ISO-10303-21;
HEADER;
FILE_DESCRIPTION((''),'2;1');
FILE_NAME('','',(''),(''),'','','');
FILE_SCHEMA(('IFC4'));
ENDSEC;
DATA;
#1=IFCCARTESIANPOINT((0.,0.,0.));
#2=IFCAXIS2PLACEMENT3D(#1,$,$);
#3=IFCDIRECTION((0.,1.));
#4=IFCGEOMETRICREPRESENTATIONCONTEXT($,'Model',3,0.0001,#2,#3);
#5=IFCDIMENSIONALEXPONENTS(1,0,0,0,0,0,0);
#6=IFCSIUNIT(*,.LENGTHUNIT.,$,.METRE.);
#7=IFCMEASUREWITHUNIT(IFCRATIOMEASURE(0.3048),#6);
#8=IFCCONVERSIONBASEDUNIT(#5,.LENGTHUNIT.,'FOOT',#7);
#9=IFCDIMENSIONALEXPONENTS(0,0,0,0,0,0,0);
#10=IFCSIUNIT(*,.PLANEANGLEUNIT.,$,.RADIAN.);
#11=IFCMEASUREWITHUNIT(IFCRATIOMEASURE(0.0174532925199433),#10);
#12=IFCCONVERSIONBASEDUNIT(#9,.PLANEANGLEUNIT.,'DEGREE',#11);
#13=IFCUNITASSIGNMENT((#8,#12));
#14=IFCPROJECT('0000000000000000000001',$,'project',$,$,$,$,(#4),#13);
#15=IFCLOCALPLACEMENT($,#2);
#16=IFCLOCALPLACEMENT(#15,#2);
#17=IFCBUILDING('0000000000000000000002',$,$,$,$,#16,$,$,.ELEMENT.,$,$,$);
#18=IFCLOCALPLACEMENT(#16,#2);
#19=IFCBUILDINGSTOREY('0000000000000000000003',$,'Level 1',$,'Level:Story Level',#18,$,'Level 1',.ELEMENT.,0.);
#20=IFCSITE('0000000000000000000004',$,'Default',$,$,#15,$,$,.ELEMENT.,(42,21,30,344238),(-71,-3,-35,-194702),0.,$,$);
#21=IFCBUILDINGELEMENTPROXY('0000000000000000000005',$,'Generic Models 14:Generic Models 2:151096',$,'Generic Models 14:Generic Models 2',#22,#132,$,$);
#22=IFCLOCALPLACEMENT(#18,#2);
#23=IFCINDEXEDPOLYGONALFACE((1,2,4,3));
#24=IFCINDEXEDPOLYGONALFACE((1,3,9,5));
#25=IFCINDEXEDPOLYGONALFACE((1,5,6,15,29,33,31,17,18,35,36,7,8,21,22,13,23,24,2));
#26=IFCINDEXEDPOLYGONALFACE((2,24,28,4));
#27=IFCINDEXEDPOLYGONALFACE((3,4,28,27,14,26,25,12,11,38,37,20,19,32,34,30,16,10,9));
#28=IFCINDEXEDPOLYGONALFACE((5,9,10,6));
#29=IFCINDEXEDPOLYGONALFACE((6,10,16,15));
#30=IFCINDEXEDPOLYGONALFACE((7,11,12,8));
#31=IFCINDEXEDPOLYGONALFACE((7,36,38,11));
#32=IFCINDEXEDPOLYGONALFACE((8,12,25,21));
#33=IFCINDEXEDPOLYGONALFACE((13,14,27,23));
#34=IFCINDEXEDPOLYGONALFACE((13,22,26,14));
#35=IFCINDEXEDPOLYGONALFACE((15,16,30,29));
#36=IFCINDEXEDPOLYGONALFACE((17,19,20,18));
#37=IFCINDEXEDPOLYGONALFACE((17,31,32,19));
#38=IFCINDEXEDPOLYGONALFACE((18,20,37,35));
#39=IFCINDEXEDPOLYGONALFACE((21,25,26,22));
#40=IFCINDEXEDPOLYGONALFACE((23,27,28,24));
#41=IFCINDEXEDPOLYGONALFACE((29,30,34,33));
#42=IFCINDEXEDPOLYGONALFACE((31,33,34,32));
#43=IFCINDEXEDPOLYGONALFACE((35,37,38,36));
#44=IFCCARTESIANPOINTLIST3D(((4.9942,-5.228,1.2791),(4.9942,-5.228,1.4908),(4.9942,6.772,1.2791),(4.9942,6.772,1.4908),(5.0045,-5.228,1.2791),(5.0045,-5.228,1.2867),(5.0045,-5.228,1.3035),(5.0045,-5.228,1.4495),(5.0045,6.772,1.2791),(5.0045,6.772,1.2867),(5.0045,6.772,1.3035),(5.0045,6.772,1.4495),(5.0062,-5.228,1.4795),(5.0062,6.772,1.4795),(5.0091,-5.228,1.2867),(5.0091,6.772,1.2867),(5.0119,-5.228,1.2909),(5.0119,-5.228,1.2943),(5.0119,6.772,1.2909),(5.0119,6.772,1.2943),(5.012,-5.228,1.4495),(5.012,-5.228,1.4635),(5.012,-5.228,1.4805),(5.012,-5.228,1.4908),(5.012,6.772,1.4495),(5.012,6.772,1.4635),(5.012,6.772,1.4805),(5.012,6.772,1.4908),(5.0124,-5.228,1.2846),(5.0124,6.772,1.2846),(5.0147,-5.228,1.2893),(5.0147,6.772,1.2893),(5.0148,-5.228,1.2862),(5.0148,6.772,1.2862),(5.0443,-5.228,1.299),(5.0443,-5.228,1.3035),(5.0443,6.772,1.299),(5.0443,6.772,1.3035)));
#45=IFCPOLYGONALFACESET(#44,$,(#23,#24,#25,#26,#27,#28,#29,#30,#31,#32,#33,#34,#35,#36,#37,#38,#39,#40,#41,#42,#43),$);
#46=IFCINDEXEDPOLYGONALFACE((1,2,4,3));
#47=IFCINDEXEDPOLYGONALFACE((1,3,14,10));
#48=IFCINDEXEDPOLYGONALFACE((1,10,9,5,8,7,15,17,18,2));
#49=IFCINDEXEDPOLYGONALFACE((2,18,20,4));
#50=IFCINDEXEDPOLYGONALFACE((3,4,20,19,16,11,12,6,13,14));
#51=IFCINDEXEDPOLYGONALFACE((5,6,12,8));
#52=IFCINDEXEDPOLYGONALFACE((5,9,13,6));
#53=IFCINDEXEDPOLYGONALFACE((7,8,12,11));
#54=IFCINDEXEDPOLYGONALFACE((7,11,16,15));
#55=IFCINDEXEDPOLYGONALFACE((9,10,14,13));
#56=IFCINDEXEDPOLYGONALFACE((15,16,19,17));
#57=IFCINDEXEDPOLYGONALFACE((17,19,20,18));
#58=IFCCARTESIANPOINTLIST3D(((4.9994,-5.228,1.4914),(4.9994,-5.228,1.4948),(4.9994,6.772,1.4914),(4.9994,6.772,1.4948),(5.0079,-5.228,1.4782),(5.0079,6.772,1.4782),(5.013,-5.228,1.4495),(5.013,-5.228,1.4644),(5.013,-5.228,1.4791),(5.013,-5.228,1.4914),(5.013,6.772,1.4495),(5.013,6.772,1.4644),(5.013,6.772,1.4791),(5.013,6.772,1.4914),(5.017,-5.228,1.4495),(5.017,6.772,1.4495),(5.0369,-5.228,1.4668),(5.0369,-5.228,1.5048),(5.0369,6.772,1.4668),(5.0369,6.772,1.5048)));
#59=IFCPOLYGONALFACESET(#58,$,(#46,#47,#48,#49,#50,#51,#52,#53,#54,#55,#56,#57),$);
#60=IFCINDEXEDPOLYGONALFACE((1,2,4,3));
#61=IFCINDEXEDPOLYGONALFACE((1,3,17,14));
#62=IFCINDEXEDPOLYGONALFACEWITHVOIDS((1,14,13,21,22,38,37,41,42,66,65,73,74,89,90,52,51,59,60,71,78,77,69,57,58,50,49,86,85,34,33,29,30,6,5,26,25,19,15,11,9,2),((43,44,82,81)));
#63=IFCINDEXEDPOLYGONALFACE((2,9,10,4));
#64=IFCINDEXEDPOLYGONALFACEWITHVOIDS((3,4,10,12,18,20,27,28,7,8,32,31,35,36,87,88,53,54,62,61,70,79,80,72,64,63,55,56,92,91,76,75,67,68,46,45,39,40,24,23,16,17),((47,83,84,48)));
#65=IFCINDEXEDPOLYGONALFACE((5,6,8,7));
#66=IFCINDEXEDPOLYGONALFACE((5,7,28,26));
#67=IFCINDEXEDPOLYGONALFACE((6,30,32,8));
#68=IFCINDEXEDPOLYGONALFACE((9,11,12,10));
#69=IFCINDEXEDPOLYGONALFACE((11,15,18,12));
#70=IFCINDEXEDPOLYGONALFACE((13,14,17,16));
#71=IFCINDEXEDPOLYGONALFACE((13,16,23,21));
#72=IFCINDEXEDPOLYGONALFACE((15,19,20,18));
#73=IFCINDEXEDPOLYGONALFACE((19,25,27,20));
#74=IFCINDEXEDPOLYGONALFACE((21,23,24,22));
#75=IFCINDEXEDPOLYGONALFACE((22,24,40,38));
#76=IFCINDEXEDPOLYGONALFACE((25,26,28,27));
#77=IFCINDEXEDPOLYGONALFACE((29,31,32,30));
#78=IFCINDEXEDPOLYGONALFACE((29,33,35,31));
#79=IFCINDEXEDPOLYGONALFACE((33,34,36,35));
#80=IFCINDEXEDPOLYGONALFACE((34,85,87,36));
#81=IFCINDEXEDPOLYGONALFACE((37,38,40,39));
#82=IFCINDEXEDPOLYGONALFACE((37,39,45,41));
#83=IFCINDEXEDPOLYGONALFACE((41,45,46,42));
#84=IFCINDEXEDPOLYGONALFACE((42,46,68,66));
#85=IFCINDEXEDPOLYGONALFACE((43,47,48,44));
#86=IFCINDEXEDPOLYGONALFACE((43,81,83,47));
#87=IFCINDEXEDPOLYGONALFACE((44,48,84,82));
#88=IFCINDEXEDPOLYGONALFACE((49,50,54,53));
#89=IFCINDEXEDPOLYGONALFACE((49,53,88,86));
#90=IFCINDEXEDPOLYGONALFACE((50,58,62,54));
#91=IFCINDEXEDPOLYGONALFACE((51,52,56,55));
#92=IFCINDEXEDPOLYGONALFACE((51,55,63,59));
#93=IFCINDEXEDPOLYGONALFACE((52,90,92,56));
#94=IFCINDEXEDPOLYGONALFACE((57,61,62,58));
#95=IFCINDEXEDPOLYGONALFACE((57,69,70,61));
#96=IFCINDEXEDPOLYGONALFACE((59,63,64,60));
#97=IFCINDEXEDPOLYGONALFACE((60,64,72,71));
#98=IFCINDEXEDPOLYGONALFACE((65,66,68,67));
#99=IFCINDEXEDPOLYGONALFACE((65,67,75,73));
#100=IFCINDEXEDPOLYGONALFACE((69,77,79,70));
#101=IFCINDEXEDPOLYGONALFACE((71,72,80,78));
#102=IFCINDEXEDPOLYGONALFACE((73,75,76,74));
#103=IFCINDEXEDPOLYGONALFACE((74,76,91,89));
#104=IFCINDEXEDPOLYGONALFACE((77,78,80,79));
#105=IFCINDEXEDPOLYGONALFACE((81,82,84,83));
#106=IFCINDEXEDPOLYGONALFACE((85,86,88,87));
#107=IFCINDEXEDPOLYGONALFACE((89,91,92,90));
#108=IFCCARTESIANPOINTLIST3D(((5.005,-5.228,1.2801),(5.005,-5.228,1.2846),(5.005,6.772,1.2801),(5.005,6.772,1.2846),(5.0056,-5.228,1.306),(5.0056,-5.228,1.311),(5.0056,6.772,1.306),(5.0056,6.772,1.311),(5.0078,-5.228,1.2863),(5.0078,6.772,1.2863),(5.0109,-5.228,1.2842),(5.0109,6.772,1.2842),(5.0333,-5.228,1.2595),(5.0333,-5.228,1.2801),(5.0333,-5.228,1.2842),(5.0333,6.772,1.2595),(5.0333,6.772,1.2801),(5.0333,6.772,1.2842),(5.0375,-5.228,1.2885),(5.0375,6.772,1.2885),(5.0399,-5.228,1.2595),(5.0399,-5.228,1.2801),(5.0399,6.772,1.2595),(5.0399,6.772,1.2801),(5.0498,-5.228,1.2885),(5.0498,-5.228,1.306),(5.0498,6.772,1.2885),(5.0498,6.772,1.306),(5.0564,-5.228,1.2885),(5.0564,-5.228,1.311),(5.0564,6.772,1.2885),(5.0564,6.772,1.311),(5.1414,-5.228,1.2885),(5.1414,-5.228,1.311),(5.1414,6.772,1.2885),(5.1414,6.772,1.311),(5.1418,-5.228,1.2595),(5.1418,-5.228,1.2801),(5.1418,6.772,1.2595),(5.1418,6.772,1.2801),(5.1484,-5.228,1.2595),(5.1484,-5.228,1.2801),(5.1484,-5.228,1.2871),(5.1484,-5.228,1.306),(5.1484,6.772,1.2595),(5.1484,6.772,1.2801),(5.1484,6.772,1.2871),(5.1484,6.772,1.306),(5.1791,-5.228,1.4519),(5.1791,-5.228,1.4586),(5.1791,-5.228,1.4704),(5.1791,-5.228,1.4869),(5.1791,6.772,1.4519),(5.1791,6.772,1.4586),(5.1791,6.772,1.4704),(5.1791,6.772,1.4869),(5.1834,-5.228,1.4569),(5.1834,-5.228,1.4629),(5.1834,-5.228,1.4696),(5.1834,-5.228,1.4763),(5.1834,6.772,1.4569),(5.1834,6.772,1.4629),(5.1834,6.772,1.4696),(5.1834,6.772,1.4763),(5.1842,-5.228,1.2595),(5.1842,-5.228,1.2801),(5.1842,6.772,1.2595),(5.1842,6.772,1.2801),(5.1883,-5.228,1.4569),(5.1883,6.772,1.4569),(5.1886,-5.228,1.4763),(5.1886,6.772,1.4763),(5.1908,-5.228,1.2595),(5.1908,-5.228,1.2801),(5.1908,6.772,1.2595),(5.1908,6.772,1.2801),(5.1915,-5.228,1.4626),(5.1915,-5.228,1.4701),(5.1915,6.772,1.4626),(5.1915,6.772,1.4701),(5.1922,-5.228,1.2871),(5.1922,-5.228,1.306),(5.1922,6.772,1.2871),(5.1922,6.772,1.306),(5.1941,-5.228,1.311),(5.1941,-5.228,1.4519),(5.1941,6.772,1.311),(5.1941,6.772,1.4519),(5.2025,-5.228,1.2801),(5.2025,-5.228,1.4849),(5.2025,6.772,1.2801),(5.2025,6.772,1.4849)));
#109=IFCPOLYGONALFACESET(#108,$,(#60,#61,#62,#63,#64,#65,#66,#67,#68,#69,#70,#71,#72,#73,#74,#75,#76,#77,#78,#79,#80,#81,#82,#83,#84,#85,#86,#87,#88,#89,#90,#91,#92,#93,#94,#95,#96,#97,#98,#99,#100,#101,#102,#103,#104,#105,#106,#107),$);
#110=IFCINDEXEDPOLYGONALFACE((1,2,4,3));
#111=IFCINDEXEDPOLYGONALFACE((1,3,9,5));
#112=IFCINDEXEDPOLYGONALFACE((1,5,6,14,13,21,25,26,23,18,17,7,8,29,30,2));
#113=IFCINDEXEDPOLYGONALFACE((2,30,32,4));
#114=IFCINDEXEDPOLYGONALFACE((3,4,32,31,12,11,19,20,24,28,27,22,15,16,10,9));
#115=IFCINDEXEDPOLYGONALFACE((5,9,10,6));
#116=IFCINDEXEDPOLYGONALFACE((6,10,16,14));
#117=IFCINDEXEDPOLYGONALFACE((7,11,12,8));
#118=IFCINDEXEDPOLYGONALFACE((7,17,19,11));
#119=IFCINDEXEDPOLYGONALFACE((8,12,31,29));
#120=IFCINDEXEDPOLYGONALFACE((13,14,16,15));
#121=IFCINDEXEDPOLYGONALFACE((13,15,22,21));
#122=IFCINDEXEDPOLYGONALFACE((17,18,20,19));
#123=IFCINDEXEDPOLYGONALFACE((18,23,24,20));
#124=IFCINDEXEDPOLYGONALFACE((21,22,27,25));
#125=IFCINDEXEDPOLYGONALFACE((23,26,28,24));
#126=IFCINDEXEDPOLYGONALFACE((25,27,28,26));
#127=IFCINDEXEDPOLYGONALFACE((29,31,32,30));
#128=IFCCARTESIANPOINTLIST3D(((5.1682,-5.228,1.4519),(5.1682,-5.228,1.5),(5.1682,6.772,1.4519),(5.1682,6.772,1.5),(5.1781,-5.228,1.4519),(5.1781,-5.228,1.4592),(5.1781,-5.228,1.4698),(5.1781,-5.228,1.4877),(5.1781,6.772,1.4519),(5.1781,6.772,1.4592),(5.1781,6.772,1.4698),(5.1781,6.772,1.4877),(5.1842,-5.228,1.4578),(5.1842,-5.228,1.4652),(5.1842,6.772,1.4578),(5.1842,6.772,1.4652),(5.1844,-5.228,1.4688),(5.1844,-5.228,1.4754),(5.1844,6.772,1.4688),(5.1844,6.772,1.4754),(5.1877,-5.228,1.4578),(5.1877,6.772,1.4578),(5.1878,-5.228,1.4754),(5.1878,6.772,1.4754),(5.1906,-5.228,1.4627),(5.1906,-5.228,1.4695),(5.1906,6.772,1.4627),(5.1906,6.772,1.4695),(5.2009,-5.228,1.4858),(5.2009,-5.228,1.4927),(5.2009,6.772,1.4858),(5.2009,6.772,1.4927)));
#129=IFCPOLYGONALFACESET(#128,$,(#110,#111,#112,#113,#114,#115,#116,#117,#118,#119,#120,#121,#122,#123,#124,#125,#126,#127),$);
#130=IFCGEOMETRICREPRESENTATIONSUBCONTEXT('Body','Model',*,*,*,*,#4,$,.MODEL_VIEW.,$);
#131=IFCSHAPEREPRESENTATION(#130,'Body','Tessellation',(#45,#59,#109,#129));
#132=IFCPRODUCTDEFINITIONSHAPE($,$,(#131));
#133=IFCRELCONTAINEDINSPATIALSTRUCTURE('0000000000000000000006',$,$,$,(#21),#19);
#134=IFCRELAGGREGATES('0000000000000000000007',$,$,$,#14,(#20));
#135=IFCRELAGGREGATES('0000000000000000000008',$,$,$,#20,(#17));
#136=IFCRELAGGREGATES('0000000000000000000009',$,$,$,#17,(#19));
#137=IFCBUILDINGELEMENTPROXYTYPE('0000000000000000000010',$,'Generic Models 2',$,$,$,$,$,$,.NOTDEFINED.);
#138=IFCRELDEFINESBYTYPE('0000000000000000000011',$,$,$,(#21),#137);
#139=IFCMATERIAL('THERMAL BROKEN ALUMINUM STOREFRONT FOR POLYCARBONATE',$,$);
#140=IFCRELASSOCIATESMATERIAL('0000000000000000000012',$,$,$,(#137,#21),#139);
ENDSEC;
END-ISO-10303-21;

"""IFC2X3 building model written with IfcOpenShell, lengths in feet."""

from ifc_helpers import new_model, entity, si_unit, converted_unit, direction, frame, origin, place, context, subcontext, project, spatial, polyline, outline, extrude, source, transform, mapped, material, type_object, type_shapes, element, save


model = new_model("IFC2X3")

# Units and contexts
model_context = context("Model", 3, precision=0.0001, world=origin(), true_north=direction((0.0, 1.0)))
body_context = subcontext(model_context, "Body", "Model", "MODEL_VIEW")
ifc_project = project(units=[converted_unit("LENGTHUNIT", "FOOT", entity("IfcRatioMeasure", 0.3048), si_unit("LENGTHUNIT", "METRE"), dimensions=[1, 0, 0, 0, 0, 0, 0]), converted_unit("PLANEANGLEUNIT", "DEGREE", entity("IfcRatioMeasure", 0.0174532925199433), si_unit("PLANEANGLEUNIT", "RADIAN"), dimensions=[0, 0, 0, 0, 0, 0, 0])], contexts=[model_context])

# Site, building, storey
site_placement = place(None, origin())
site = spatial("IfcSite", under=ifc_project, at=site_placement, Name="Default", CompositionType="ELEMENT", RefLatitude=(42, 21, 30, 344238), RefLongitude=(-71, -3, -35, -194702), RefElevation=0.0)
building_placement = place(site_placement, origin())
building = spatial("IfcBuilding", under=site, at=building_placement, CompositionType="ELEMENT")
storey_placement = place(building_placement, origin())
storey = spatial("IfcBuildingStorey", under=building, at=storey_placement, Name="Level 1", ObjectType="Level:Story Level", LongName="Level 1", CompositionType="ELEMENT", Elevation=0.0)

# Building element proxy
ifc_material = material(Name="THERMAL BROKEN ALUMINUM STOREFRONT FOR POLYCARBONATE")
building_element_proxy_type_1 = type_object("IfcBuildingElementProxyType", Name="Generic Models 2", PredefinedType="NOTDEFINED", material=ifc_material)
shared_shape_1 = source(origin(), body_context, "Body", "SweptSolid", [
    extrude(outline(polyline([(0.068, 0.0006), (0.0711, 0.0006), (0.0726, 0.0031), (0.0702, 0.0064), (0.07, 0.011), (0.0776, 0.0114), (0.0771, 0.0217), (-0.1343, 0.0107), (-0.1334, -0.0072), (-0.1231, -0.0066), (-0.1224, -0.0008), (-0.1062, -0.0058), (-0.0922, -0.005), (-0.0926, 0.0025), (0.0533, 0.0101), (0.0554, -0.0297), (0.0599, -0.0295), (0.0628, 0.0032), (0.0663, 0.0034), (0.068, 0.0006)])), frame((-15.0475, 0.32, 0.0977), z_axis=(1.0, 0.0, 0.0), x_axis=(0.0, -0.051774, -0.998659)), (0.0, 0.0, 1.0), 12.0),
    extrude(outline(polyline([(-0.0104, -0.0212), (0.0284, -0.0212), (0.0186, 0.0156), (-0.0052, 0.0271), (-0.009, 0.026), (-0.0051, 0.0117), (-0.0065, -0.003), (-0.0014, -0.0025), (0.0018, -0.0144), (-0.0113, -0.0179), (-0.0104, -0.0212)])), frame((-15.0475, 0.3168, 0.2175), z_axis=(1.0, 0.0, 0.0), x_axis=(0.0, -0.966235, 0.257663)), (0.0, 0.0, 1.0), 12.0),
    extrude(outline(polyline([(-0.073, 0.107), (-0.058, 0.107), (-0.058, 0.1137), (-0.0623, 0.118), (-0.0623, 0.1121), (-0.0672, 0.1121), (-0.0704, 0.1177), (-0.0704, 0.1252), (-0.0675, 0.1315), (-0.0623, 0.1315), (-0.0623, 0.1248), (-0.058, 0.1255), (-0.058, 0.142), (-0.0814, 0.1401), (-0.0814, -0.0647), (-0.0697, -0.0647), (-0.0697, -0.0853), (-0.0631, -0.0853), (-0.0631, -0.0647), (-0.0273, -0.0647), (-0.0273, -0.0853), (-0.0207, -0.0853), (-0.0207, -0.0647), (0.0812, -0.0647), (0.0812, -0.0853), (0.0878, -0.0853), (0.0878, -0.0647), (0.1161, -0.0647), (0.1161, -0.0603), (0.1133, -0.0585), (0.1102, -0.0606), (0.0878, -0.0606), (0.0836, -0.0564), (0.0713, -0.0564), (0.0713, -0.0389), (0.1155, -0.0389), (0.1155, -0.0338), (0.0647, -0.0338), (0.0647, -0.0564), (-0.0203, -0.0564), (-0.0203, -0.0338), (-0.073, -0.0338), (-0.073, 0.107)]), holes=[polyline([(-0.0711, -0.0577), (-0.0711, -0.0389), (-0.0273, -0.0389), (-0.0273, -0.0577), (-0.0711, -0.0577)])]), frame((-15.0475, 0.2107, 0.0853), z_axis=(1.0, 0.0, 0.0), x_axis=(0.0, 1.0, 0.0)), (0.0, 0.0, 1.0), 12.0),
    extrude(outline(polyline([(-0.0218, -0.0251), (0.0116, -0.0251), (0.0131, -0.0183), (-0.0094, -0.0153), (-0.0056, 0.0021), (0.0008, 0.0018), (-0.0006, -0.0047), (0.0027, -0.0054), (0.0066, -0.0003), (0.0081, 0.0064), (0.0064, 0.0118), (0.0029, 0.0126), (0.0013, 0.0053), (-0.0032, 0.0125), (-0.0017, 0.0197), (-0.0114, 0.0218), (-0.0218, -0.0251)])), frame((-15.0475, 0.1478, 0.2112), z_axis=(1.0, 0.0, 0.0), x_axis=(0.0, -0.976068, -0.217466)), (0.0, 0.0, 1.0), 12.0),
])
type_shapes(building_element_proxy_type_1, [shared_shape_1])
proxy_1_placement = place(storey_placement, frame((5.3318, 9.8195, 1.2595), z_axis=(0.0, 0.0, 1.0), x_axis=(0.0, 1.0, 0.0)))
element("IfcBuildingElementProxy", 1, at=proxy_1_placement, inside=storey, type_object=building_element_proxy_type_1, material=ifc_material, Name="Generic Models 14:Generic Models 2:151096", ObjectType="Generic Models 14:Generic Models 2", context=body_context, shape_type="MappedRepresentation", body=[
    mapped(shared_shape_1, transform((0.0, 0.0, 0.0), scale=1.0)),
])

save(model, "model.ifc")
